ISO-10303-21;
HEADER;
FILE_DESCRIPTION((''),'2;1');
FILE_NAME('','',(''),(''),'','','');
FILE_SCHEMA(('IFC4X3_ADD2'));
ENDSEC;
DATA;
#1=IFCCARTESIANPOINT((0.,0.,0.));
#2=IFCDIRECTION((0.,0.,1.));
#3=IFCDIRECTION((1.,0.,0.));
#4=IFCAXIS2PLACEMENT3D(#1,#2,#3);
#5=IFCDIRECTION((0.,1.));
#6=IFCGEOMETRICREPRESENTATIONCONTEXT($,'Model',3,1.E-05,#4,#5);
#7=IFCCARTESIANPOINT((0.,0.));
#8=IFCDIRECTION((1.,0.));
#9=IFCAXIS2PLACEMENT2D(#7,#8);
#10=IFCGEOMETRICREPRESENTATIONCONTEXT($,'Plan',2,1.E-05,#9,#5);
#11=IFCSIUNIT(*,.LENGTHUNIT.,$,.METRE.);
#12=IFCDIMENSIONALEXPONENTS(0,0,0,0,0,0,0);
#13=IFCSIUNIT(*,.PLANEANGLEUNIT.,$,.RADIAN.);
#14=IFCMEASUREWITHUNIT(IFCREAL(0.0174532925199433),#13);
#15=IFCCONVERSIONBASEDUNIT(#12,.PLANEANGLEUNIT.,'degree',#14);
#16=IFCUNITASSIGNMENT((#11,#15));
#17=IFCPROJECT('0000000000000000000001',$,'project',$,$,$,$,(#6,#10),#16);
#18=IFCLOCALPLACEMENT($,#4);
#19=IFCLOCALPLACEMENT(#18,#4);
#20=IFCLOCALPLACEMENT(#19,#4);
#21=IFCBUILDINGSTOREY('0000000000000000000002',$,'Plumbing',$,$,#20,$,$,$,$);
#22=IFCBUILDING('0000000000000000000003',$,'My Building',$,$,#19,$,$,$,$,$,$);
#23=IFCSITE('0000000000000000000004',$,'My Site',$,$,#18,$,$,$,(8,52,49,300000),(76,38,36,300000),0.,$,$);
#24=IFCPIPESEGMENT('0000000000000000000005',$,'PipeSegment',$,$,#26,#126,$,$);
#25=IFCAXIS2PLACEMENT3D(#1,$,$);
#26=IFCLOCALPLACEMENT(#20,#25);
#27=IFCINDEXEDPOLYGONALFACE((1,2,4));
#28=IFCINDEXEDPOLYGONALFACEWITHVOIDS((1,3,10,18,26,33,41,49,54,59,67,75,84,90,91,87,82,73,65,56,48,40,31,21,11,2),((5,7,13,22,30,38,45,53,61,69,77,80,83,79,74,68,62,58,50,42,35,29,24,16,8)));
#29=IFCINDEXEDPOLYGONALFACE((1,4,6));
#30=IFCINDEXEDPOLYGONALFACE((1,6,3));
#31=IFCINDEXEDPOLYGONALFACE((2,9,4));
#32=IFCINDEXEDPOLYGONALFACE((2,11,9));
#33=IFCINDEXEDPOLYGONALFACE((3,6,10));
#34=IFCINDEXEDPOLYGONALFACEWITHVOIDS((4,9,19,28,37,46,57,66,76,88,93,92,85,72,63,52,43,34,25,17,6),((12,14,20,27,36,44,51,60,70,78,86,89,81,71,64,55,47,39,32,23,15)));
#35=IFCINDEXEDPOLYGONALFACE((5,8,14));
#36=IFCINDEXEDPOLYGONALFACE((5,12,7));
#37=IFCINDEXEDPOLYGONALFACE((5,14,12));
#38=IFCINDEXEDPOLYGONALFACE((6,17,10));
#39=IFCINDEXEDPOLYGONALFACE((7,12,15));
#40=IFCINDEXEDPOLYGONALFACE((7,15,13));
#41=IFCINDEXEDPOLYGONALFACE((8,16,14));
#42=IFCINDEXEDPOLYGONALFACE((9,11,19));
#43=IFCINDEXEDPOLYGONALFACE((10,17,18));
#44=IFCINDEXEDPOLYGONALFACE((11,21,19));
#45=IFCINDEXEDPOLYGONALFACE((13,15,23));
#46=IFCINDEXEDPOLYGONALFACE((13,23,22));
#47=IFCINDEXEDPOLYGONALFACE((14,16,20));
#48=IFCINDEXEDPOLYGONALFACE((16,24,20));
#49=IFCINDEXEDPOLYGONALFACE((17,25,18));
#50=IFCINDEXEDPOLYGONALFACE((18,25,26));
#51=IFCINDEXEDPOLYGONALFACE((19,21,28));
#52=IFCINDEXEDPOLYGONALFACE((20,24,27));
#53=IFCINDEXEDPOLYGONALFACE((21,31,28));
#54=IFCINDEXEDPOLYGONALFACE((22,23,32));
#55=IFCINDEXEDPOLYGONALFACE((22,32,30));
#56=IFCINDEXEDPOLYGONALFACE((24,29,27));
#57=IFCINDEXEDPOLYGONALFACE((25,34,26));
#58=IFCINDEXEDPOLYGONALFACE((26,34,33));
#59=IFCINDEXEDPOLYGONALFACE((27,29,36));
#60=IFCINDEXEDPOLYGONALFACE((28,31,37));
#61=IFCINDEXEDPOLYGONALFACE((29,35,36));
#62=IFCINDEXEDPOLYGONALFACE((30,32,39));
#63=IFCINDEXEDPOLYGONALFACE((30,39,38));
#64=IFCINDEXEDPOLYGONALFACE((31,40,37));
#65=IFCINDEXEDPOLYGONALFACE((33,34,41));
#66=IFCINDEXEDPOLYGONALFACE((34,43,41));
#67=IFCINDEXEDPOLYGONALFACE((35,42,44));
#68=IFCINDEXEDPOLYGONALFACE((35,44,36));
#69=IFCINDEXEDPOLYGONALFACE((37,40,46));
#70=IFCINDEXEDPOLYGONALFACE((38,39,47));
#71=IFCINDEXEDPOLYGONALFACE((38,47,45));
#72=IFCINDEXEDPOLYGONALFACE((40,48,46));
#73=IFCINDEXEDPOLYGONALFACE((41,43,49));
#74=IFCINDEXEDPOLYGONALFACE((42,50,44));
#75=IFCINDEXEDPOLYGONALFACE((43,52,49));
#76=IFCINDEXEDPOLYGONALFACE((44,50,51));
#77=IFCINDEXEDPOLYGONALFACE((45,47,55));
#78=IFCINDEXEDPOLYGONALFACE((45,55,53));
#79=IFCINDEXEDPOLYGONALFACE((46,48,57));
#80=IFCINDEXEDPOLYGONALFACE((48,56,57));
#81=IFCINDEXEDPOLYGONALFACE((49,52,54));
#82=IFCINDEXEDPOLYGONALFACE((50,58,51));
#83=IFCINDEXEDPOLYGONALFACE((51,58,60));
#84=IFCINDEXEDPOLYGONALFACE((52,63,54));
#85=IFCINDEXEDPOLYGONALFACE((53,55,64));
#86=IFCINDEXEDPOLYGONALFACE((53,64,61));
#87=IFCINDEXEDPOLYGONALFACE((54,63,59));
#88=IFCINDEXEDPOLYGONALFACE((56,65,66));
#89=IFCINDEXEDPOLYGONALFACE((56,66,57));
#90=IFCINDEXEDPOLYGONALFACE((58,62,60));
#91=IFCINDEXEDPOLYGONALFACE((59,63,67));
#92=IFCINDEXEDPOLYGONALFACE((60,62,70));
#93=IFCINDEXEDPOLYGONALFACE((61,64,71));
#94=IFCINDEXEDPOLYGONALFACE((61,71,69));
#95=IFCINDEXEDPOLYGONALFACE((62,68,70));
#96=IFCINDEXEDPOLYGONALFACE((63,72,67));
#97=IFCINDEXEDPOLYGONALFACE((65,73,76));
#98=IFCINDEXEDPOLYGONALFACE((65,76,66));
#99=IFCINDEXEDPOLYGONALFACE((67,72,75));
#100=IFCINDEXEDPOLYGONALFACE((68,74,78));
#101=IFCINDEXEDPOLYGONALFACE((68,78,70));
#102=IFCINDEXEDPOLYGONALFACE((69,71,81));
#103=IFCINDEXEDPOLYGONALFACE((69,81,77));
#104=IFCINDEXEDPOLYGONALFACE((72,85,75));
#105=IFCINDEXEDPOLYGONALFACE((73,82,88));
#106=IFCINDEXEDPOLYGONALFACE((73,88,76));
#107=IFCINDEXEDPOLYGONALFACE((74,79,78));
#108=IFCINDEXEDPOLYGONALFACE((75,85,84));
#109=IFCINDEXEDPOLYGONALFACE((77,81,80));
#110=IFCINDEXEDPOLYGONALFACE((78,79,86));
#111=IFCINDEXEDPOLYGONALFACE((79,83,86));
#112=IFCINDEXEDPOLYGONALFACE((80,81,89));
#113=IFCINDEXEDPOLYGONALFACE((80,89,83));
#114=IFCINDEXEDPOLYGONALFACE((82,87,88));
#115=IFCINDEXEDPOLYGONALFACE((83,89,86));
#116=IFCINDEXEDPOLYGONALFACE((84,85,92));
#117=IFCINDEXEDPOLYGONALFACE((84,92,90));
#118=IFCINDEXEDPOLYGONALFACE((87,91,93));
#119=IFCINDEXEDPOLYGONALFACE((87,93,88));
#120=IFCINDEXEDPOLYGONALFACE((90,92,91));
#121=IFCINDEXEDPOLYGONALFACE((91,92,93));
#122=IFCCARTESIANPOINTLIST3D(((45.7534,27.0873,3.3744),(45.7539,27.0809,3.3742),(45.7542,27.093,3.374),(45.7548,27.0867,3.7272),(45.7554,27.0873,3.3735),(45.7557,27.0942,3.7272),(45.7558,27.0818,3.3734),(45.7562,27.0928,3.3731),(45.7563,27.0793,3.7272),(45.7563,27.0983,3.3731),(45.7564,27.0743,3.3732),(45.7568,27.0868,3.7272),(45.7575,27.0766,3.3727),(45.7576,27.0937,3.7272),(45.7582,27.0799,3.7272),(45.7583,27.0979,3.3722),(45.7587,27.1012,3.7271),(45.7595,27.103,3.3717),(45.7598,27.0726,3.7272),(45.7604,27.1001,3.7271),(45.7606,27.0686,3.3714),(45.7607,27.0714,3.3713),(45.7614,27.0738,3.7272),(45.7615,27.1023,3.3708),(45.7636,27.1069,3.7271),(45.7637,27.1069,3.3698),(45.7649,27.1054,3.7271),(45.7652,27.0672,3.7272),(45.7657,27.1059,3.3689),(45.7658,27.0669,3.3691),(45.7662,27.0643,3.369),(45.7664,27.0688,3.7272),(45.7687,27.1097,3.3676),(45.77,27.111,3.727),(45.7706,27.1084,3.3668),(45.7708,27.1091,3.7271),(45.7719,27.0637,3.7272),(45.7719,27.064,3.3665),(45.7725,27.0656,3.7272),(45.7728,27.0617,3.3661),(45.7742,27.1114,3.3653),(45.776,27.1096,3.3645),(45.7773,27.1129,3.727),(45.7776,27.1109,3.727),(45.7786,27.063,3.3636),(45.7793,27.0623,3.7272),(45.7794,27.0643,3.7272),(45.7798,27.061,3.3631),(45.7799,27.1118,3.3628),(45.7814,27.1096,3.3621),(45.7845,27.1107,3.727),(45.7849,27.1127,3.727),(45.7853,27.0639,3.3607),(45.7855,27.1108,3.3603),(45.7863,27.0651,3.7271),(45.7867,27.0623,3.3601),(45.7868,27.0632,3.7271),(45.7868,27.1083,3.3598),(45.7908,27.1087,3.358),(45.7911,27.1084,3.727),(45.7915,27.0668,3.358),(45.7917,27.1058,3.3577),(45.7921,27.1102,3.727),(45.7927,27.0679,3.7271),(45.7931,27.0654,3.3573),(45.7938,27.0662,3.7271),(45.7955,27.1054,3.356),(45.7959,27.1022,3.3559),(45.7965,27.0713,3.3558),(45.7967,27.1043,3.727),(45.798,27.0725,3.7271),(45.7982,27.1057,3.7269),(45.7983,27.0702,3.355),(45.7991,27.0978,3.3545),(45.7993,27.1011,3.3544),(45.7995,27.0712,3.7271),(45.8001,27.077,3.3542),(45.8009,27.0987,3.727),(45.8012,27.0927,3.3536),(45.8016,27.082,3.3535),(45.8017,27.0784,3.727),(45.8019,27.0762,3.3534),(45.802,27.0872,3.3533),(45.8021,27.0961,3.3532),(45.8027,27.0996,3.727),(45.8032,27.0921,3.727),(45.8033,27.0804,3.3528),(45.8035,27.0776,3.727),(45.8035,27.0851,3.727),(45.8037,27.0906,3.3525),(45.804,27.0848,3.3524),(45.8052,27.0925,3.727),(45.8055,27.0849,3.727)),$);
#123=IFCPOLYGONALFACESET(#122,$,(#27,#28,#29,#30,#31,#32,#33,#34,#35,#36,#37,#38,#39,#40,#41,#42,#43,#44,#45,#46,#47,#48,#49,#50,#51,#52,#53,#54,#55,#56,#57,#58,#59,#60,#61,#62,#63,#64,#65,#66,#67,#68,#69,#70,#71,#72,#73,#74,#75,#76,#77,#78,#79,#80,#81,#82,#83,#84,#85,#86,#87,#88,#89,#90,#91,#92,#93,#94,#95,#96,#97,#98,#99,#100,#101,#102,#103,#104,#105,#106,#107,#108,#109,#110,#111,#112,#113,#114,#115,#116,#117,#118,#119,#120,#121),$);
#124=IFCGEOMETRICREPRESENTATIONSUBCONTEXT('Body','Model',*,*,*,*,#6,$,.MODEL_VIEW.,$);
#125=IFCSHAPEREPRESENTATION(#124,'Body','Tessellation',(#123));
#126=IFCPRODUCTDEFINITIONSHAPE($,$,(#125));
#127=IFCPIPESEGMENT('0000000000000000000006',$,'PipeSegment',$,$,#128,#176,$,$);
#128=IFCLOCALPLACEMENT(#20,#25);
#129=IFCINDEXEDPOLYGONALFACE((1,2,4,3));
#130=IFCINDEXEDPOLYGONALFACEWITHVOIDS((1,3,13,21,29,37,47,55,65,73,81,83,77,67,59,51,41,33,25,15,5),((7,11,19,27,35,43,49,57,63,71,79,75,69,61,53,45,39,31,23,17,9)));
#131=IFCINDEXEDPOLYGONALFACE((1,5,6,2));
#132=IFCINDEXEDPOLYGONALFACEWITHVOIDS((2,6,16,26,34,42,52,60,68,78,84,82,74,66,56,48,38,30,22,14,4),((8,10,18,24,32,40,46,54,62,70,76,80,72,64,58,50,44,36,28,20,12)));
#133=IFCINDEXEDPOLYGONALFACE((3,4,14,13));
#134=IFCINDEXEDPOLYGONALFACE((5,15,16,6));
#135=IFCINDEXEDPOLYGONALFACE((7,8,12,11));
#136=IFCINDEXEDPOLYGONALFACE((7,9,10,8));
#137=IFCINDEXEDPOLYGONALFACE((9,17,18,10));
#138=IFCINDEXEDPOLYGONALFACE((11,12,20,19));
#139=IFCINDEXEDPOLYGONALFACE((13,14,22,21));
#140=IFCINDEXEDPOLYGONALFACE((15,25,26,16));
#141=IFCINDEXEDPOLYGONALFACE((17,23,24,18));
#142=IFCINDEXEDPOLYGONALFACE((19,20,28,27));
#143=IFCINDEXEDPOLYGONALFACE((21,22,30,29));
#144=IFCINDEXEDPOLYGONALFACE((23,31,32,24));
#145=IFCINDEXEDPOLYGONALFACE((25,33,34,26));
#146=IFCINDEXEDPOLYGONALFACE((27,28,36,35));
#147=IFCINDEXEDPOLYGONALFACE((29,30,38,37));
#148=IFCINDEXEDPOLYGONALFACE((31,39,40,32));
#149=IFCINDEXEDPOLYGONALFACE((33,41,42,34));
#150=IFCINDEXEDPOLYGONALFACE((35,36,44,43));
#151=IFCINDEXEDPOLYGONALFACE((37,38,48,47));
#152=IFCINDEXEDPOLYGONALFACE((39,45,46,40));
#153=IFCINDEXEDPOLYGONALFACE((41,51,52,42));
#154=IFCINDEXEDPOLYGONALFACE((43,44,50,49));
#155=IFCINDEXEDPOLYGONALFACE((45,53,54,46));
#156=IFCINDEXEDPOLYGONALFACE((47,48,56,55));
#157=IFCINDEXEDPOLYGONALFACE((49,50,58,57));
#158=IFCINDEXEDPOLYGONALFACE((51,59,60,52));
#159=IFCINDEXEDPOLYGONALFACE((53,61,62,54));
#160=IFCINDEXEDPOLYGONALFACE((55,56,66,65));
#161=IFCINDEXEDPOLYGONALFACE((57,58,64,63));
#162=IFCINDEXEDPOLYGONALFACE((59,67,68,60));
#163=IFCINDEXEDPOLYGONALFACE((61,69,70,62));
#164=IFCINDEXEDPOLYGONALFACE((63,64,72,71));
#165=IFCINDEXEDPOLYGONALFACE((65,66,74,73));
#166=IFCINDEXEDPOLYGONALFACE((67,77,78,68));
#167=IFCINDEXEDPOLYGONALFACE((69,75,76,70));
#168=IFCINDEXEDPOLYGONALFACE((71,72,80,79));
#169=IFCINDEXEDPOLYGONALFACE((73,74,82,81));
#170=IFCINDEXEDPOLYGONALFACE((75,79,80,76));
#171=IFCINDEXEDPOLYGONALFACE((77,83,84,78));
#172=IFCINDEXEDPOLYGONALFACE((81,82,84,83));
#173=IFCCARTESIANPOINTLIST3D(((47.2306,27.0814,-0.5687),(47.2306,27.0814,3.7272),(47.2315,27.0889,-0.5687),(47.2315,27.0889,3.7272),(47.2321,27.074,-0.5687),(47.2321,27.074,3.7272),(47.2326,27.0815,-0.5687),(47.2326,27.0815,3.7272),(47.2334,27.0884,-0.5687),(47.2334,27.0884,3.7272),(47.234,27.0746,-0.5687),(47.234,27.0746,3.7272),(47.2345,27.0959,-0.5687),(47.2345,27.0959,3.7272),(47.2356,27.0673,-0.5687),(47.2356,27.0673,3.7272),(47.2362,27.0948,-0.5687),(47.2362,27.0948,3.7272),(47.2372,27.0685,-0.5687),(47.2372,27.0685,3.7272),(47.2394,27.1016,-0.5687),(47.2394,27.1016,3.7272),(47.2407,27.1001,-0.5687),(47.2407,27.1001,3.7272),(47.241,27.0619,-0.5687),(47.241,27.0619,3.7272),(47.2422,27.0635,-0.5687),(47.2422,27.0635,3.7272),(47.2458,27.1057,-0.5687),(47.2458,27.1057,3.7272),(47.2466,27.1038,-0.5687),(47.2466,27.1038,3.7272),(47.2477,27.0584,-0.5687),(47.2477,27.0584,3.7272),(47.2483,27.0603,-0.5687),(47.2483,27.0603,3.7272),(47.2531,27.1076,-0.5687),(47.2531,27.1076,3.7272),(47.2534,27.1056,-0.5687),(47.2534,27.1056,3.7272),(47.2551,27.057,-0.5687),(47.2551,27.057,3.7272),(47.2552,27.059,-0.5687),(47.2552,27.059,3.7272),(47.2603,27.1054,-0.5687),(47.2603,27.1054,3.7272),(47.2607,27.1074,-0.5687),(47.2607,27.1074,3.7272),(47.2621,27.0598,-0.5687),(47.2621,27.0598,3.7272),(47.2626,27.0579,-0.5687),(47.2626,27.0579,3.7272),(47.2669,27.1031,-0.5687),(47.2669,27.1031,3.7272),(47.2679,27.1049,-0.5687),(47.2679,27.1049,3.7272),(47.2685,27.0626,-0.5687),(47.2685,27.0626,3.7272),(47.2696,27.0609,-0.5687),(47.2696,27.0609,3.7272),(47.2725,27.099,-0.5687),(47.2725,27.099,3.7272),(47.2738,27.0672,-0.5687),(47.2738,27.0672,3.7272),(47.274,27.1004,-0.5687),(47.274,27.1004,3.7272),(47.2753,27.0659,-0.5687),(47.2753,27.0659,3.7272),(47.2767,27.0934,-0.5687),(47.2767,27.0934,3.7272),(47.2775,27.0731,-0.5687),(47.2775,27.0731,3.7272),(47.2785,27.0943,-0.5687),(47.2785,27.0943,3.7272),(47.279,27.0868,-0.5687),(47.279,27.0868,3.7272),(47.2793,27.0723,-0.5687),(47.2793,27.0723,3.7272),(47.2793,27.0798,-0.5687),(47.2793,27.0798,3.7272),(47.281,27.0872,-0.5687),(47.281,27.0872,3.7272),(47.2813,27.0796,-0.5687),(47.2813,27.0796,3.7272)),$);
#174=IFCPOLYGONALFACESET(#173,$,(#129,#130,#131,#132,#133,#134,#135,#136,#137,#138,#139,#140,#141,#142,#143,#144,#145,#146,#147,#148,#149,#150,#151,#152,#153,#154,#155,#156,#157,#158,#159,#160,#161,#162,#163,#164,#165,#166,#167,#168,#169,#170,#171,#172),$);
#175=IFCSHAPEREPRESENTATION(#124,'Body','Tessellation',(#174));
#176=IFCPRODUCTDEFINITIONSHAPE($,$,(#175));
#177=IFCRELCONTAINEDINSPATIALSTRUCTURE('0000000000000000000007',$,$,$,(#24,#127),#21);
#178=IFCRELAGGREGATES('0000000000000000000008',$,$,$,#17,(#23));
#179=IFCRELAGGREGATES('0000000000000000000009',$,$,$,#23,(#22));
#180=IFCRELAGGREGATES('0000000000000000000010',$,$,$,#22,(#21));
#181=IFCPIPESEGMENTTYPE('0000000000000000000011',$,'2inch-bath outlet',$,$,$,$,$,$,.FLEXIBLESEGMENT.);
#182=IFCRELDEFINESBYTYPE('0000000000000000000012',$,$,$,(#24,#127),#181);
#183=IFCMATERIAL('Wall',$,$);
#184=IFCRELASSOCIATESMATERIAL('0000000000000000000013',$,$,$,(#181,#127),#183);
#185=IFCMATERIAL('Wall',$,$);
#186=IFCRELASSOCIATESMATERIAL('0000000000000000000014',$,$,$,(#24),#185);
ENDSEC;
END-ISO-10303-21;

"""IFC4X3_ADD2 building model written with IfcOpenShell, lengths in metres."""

from ifc_helpers import new_model, entity, si_unit, converted_unit, direction, frame, origin_with_axes, origin_2d_with_axis, place, context, subcontext, project, spatial, hollow_circle, extrude, clip, halfspace, material, material_profile, profile_set, profile_usage, type_object, element, save


model = new_model("IFC4X3_ADD2")

# Units and contexts
model_context = context("Model", 3, precision=1e-05, world=origin_with_axes(), true_north=direction((0.0, 1.0)))
plan_context = context("Plan", 2, precision=1e-05, world=origin_2d_with_axis(), true_north=direction((0.0, 1.0)))
body_context = subcontext(model_context, "Body", "Model", "MODEL_VIEW")
ifc_project = project(units=[si_unit("LENGTHUNIT", "METRE"), converted_unit("PLANEANGLEUNIT", "degree", entity("IfcReal", 0.0174532925199433), si_unit("PLANEANGLEUNIT", "RADIAN"), dimensions=[0, 0, 0, 0, 0, 0, 0])], contexts=[model_context, plan_context])

# Site, building, storey
site_placement = place(None, origin_with_axes())
site = spatial("IfcSite", under=ifc_project, at=site_placement, Name="My Site", RefLatitude=(8, 52, 49, 300000), RefLongitude=(76, 38, 36, 300000), RefElevation=0.0)
building_placement = place(site_placement, origin_with_axes())
building = spatial("IfcBuilding", under=site, at=building_placement, Name="My Building")
storey_placement = place(building_placement, origin_with_axes())
storey = spatial("IfcBuildingStorey", under=building, at=storey_placement, Name="Plumbing")

# Pipe segments
ifc_material_1 = material(Name="Wall")
ifc_material_profile_1 = material_profile(ifc_material_1, hollow_circle(Radius=0.0254, WallThickness=0.002))
ifc_profile_set_1 = profile_set([ifc_material_profile_1], Name="graywater")
ifc_material_2 = material(Name="Wall")
ifc_material_profile_2 = material_profile(ifc_material_2, hollow_circle(Radius=0.0254, WallThickness=0.002))
ifc_profile_set_2 = profile_set([ifc_material_profile_2], Name="graywater")
pipe_segment_type_1 = type_object("IfcPipeSegmentType", Name="2inch-bath outlet", PredefinedType="FLEXIBLESEGMENT", material=ifc_profile_set_2)
ifc_profile_usage_1 = profile_usage(ifc_profile_set_1, cardinal=5)
pipe_segment_1_placement = place(storey_placement, frame((45.7785, 27.0862, 3.3126), z_axis=(0.004219, 0.003594, 0.999985), x_axis=(0.917305, -0.398179, -0.002439)))
element("IfcPipeSegment", 1, at=pipe_segment_1_placement, inside=storey, type_object=pipe_segment_type_1, material=ifc_profile_usage_1, Name="PipeSegment", context=body_context, shape_type="Clipping", body=[
    clip(extrude(hollow_circle(Radius=0.0254, WallThickness=0.002), origin_with_axes(), (0.0, 0.0, 1.0), 0.4145), halfspace(frame((-0.0036, 0.0187, 0.049), z_axis=(-0.361019, -0.158535, -0.918984), x_axis=(-0.402072, 0.915608, 0.0)), False)),
])
ifc_profile_usage_2 = profile_usage(ifc_profile_set_2, cardinal=5)
pipe_segment_2_placement = place(storey_placement, frame((47.256, 27.0824, -0.5687), z_axis=(0.0, 0.0, 1.0), x_axis=(0.917307, -0.39818, 0.0)))
element("IfcPipeSegment", 2, at=pipe_segment_2_placement, inside=storey, type_object=pipe_segment_type_1, material=ifc_profile_usage_2, Name="PipeSegment", context=body_context, shape_type="SweptSolid", body=[
    extrude(hollow_circle(Radius=0.0254, WallThickness=0.002), origin_with_axes(), (0.0, 0.0, 1.0), 4.2959),
])

save(model, "model.ifc")
